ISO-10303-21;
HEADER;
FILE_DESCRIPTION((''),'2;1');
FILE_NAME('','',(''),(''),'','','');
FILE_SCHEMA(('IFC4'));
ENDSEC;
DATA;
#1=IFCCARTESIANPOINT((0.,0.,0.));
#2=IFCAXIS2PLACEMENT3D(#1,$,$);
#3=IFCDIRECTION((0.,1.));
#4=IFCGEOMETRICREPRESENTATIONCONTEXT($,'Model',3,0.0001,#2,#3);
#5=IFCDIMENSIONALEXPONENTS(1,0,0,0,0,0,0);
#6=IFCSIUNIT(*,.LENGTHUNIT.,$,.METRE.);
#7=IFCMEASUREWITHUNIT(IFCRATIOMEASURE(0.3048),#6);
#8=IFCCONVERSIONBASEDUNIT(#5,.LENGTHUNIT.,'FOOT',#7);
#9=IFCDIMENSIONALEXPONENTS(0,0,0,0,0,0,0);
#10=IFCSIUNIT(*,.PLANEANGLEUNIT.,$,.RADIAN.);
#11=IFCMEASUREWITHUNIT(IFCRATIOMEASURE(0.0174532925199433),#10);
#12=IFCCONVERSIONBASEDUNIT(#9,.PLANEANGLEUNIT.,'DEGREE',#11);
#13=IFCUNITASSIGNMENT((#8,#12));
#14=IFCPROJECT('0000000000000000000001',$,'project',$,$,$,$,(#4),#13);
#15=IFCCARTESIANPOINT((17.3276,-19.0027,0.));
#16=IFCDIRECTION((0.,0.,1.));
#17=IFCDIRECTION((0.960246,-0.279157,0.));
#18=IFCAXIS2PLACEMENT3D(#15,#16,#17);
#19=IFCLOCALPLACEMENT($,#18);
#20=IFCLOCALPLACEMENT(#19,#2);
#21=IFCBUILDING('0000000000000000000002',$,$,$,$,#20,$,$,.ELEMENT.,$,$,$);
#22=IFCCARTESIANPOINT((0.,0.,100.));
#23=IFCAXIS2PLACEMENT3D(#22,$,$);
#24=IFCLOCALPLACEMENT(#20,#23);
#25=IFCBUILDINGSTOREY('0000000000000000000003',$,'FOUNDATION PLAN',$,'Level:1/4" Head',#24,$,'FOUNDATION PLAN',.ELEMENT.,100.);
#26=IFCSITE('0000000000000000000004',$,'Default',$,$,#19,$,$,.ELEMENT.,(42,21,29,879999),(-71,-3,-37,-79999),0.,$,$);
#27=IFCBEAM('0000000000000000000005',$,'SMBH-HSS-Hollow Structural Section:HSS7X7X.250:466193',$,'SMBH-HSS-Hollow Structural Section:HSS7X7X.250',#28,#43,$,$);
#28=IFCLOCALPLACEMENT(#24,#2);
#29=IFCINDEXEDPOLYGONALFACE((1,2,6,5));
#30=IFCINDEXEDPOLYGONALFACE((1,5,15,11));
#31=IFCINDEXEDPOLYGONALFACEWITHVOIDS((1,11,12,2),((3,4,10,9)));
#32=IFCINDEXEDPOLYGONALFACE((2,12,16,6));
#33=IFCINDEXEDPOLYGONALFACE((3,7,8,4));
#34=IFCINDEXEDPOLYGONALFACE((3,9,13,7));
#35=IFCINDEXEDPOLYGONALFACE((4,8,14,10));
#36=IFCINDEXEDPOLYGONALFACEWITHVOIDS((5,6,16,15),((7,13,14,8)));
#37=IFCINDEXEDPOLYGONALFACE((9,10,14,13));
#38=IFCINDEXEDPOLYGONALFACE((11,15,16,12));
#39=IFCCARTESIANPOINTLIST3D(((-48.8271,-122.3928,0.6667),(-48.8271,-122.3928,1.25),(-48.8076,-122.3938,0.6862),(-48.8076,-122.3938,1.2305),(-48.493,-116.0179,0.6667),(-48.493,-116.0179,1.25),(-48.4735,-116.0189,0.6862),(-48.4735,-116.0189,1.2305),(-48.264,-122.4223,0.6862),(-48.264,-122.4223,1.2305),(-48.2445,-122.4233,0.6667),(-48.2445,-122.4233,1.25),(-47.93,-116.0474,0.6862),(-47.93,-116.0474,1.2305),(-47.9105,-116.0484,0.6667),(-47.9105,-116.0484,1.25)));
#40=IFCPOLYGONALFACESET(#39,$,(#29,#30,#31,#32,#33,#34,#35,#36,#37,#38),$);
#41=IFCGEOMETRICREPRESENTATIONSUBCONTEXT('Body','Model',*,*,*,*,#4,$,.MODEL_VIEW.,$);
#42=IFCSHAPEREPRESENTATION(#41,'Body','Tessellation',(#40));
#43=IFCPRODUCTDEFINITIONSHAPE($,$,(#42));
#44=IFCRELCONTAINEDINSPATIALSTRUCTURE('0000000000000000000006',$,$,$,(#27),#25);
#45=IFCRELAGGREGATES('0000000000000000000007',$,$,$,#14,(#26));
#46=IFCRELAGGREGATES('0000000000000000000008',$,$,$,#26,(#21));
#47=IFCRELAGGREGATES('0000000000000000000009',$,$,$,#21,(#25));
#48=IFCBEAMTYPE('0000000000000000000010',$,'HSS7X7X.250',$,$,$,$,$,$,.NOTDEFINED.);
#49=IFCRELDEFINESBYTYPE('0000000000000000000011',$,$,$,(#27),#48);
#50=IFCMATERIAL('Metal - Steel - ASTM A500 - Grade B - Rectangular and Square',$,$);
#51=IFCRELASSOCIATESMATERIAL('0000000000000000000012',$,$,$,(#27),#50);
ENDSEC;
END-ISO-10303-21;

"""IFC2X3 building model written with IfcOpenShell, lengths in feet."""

from ifc_helpers import new_model, entity, si_unit, converted_unit, direction, frame, frame_2d, origin, place, context, subcontext, project, spatial, rectangle, extrude, boolean, material, type_object, element, save


model = new_model("IFC2X3")

# Units and contexts
model_context = context("Model", 3, precision=0.0001, world=origin(), true_north=direction((0.0, 1.0)))
body_context = subcontext(model_context, "Body", "Model", "MODEL_VIEW")
ifc_project = project(units=[converted_unit("LENGTHUNIT", "FOOT", entity("IfcRatioMeasure", 0.3048), si_unit("LENGTHUNIT", "METRE"), dimensions=[1, 0, 0, 0, 0, 0, 0]), converted_unit("PLANEANGLEUNIT", "DEGREE", entity("IfcRatioMeasure", 0.0174532925199433), si_unit("PLANEANGLEUNIT", "RADIAN"), dimensions=[0, 0, 0, 0, 0, 0, 0])], contexts=[model_context])

# Site, building, storey
site_placement = place(None, frame((17.3276, -19.0027, 0.0), z_axis=(0.0, 0.0, 1.0), x_axis=(0.960246, -0.279157, 0.0)))
site = spatial("IfcSite", under=ifc_project, at=site_placement, Name="Default", CompositionType="ELEMENT", RefLatitude=(42, 21, 29, 879999), RefLongitude=(-71, -3, -37, -79999), RefElevation=0.0)
building_placement = place(site_placement, origin())
building = spatial("IfcBuilding", under=site, at=building_placement, CompositionType="ELEMENT")
storey_placement = place(building_placement, frame((0.0, 0.0, 100.0)))
storey = spatial("IfcBuildingStorey", under=building, at=storey_placement, Name="FOUNDATION PLAN", ObjectType="Level:1/4\" Head", LongName="FOUNDATION PLAN", CompositionType="ELEMENT", Elevation=100.0)

# Shared definitions
ifc_material_1 = material(Name="Metal - Steel - ASTM A500 - Grade B - Rectangular and Square")

# Beam
beam_type_1 = type_object("IfcBeamType", Name="HSS7X7X.250", PredefinedType="NOTDEFINED")
beam_1_placement = place(storey_placement, frame((-48.2017, -116.0332, 1.25), z_axis=(0.0, 0.0, 1.0), x_axis=(-0.052336, -0.99863, 0.0)))
element("IfcBeam", 1, at=beam_1_placement, inside=storey, type_object=beam_type_1, material=ifc_material_1, Name="SMBH-HSS-Hollow Structural Section:HSS7X7X.250:466193", ObjectType="SMBH-HSS-Hollow Structural Section:HSS7X7X.250", context=body_context, shape_type="SweptSolid", body=[
    boolean("DIFFERENCE", extrude(rectangle(XDim=0.5833, YDim=0.5833, at=frame_2d((0.0, 0.0), x_axis=(1.0, 0.0))), frame((0.0, 0.0, -0.2917), z_axis=(1.0, 0.0, 0.0), x_axis=(0.0, 0.0, -1.0)), (0.0, 0.0, 1.0), 6.3836), extrude(rectangle(XDim=0.5443, YDim=0.5443, at=frame_2d((0.0, 0.0), x_axis=(0.0, 1.0))), frame((6.3836, 0.0, -0.2917), z_axis=(-1.0, 0.0, 0.0), x_axis=(0.0, 1.0, 0.0)), (0.0, 0.0, 1.0), 6.3836)),
])

save(model, "model.ifc")
